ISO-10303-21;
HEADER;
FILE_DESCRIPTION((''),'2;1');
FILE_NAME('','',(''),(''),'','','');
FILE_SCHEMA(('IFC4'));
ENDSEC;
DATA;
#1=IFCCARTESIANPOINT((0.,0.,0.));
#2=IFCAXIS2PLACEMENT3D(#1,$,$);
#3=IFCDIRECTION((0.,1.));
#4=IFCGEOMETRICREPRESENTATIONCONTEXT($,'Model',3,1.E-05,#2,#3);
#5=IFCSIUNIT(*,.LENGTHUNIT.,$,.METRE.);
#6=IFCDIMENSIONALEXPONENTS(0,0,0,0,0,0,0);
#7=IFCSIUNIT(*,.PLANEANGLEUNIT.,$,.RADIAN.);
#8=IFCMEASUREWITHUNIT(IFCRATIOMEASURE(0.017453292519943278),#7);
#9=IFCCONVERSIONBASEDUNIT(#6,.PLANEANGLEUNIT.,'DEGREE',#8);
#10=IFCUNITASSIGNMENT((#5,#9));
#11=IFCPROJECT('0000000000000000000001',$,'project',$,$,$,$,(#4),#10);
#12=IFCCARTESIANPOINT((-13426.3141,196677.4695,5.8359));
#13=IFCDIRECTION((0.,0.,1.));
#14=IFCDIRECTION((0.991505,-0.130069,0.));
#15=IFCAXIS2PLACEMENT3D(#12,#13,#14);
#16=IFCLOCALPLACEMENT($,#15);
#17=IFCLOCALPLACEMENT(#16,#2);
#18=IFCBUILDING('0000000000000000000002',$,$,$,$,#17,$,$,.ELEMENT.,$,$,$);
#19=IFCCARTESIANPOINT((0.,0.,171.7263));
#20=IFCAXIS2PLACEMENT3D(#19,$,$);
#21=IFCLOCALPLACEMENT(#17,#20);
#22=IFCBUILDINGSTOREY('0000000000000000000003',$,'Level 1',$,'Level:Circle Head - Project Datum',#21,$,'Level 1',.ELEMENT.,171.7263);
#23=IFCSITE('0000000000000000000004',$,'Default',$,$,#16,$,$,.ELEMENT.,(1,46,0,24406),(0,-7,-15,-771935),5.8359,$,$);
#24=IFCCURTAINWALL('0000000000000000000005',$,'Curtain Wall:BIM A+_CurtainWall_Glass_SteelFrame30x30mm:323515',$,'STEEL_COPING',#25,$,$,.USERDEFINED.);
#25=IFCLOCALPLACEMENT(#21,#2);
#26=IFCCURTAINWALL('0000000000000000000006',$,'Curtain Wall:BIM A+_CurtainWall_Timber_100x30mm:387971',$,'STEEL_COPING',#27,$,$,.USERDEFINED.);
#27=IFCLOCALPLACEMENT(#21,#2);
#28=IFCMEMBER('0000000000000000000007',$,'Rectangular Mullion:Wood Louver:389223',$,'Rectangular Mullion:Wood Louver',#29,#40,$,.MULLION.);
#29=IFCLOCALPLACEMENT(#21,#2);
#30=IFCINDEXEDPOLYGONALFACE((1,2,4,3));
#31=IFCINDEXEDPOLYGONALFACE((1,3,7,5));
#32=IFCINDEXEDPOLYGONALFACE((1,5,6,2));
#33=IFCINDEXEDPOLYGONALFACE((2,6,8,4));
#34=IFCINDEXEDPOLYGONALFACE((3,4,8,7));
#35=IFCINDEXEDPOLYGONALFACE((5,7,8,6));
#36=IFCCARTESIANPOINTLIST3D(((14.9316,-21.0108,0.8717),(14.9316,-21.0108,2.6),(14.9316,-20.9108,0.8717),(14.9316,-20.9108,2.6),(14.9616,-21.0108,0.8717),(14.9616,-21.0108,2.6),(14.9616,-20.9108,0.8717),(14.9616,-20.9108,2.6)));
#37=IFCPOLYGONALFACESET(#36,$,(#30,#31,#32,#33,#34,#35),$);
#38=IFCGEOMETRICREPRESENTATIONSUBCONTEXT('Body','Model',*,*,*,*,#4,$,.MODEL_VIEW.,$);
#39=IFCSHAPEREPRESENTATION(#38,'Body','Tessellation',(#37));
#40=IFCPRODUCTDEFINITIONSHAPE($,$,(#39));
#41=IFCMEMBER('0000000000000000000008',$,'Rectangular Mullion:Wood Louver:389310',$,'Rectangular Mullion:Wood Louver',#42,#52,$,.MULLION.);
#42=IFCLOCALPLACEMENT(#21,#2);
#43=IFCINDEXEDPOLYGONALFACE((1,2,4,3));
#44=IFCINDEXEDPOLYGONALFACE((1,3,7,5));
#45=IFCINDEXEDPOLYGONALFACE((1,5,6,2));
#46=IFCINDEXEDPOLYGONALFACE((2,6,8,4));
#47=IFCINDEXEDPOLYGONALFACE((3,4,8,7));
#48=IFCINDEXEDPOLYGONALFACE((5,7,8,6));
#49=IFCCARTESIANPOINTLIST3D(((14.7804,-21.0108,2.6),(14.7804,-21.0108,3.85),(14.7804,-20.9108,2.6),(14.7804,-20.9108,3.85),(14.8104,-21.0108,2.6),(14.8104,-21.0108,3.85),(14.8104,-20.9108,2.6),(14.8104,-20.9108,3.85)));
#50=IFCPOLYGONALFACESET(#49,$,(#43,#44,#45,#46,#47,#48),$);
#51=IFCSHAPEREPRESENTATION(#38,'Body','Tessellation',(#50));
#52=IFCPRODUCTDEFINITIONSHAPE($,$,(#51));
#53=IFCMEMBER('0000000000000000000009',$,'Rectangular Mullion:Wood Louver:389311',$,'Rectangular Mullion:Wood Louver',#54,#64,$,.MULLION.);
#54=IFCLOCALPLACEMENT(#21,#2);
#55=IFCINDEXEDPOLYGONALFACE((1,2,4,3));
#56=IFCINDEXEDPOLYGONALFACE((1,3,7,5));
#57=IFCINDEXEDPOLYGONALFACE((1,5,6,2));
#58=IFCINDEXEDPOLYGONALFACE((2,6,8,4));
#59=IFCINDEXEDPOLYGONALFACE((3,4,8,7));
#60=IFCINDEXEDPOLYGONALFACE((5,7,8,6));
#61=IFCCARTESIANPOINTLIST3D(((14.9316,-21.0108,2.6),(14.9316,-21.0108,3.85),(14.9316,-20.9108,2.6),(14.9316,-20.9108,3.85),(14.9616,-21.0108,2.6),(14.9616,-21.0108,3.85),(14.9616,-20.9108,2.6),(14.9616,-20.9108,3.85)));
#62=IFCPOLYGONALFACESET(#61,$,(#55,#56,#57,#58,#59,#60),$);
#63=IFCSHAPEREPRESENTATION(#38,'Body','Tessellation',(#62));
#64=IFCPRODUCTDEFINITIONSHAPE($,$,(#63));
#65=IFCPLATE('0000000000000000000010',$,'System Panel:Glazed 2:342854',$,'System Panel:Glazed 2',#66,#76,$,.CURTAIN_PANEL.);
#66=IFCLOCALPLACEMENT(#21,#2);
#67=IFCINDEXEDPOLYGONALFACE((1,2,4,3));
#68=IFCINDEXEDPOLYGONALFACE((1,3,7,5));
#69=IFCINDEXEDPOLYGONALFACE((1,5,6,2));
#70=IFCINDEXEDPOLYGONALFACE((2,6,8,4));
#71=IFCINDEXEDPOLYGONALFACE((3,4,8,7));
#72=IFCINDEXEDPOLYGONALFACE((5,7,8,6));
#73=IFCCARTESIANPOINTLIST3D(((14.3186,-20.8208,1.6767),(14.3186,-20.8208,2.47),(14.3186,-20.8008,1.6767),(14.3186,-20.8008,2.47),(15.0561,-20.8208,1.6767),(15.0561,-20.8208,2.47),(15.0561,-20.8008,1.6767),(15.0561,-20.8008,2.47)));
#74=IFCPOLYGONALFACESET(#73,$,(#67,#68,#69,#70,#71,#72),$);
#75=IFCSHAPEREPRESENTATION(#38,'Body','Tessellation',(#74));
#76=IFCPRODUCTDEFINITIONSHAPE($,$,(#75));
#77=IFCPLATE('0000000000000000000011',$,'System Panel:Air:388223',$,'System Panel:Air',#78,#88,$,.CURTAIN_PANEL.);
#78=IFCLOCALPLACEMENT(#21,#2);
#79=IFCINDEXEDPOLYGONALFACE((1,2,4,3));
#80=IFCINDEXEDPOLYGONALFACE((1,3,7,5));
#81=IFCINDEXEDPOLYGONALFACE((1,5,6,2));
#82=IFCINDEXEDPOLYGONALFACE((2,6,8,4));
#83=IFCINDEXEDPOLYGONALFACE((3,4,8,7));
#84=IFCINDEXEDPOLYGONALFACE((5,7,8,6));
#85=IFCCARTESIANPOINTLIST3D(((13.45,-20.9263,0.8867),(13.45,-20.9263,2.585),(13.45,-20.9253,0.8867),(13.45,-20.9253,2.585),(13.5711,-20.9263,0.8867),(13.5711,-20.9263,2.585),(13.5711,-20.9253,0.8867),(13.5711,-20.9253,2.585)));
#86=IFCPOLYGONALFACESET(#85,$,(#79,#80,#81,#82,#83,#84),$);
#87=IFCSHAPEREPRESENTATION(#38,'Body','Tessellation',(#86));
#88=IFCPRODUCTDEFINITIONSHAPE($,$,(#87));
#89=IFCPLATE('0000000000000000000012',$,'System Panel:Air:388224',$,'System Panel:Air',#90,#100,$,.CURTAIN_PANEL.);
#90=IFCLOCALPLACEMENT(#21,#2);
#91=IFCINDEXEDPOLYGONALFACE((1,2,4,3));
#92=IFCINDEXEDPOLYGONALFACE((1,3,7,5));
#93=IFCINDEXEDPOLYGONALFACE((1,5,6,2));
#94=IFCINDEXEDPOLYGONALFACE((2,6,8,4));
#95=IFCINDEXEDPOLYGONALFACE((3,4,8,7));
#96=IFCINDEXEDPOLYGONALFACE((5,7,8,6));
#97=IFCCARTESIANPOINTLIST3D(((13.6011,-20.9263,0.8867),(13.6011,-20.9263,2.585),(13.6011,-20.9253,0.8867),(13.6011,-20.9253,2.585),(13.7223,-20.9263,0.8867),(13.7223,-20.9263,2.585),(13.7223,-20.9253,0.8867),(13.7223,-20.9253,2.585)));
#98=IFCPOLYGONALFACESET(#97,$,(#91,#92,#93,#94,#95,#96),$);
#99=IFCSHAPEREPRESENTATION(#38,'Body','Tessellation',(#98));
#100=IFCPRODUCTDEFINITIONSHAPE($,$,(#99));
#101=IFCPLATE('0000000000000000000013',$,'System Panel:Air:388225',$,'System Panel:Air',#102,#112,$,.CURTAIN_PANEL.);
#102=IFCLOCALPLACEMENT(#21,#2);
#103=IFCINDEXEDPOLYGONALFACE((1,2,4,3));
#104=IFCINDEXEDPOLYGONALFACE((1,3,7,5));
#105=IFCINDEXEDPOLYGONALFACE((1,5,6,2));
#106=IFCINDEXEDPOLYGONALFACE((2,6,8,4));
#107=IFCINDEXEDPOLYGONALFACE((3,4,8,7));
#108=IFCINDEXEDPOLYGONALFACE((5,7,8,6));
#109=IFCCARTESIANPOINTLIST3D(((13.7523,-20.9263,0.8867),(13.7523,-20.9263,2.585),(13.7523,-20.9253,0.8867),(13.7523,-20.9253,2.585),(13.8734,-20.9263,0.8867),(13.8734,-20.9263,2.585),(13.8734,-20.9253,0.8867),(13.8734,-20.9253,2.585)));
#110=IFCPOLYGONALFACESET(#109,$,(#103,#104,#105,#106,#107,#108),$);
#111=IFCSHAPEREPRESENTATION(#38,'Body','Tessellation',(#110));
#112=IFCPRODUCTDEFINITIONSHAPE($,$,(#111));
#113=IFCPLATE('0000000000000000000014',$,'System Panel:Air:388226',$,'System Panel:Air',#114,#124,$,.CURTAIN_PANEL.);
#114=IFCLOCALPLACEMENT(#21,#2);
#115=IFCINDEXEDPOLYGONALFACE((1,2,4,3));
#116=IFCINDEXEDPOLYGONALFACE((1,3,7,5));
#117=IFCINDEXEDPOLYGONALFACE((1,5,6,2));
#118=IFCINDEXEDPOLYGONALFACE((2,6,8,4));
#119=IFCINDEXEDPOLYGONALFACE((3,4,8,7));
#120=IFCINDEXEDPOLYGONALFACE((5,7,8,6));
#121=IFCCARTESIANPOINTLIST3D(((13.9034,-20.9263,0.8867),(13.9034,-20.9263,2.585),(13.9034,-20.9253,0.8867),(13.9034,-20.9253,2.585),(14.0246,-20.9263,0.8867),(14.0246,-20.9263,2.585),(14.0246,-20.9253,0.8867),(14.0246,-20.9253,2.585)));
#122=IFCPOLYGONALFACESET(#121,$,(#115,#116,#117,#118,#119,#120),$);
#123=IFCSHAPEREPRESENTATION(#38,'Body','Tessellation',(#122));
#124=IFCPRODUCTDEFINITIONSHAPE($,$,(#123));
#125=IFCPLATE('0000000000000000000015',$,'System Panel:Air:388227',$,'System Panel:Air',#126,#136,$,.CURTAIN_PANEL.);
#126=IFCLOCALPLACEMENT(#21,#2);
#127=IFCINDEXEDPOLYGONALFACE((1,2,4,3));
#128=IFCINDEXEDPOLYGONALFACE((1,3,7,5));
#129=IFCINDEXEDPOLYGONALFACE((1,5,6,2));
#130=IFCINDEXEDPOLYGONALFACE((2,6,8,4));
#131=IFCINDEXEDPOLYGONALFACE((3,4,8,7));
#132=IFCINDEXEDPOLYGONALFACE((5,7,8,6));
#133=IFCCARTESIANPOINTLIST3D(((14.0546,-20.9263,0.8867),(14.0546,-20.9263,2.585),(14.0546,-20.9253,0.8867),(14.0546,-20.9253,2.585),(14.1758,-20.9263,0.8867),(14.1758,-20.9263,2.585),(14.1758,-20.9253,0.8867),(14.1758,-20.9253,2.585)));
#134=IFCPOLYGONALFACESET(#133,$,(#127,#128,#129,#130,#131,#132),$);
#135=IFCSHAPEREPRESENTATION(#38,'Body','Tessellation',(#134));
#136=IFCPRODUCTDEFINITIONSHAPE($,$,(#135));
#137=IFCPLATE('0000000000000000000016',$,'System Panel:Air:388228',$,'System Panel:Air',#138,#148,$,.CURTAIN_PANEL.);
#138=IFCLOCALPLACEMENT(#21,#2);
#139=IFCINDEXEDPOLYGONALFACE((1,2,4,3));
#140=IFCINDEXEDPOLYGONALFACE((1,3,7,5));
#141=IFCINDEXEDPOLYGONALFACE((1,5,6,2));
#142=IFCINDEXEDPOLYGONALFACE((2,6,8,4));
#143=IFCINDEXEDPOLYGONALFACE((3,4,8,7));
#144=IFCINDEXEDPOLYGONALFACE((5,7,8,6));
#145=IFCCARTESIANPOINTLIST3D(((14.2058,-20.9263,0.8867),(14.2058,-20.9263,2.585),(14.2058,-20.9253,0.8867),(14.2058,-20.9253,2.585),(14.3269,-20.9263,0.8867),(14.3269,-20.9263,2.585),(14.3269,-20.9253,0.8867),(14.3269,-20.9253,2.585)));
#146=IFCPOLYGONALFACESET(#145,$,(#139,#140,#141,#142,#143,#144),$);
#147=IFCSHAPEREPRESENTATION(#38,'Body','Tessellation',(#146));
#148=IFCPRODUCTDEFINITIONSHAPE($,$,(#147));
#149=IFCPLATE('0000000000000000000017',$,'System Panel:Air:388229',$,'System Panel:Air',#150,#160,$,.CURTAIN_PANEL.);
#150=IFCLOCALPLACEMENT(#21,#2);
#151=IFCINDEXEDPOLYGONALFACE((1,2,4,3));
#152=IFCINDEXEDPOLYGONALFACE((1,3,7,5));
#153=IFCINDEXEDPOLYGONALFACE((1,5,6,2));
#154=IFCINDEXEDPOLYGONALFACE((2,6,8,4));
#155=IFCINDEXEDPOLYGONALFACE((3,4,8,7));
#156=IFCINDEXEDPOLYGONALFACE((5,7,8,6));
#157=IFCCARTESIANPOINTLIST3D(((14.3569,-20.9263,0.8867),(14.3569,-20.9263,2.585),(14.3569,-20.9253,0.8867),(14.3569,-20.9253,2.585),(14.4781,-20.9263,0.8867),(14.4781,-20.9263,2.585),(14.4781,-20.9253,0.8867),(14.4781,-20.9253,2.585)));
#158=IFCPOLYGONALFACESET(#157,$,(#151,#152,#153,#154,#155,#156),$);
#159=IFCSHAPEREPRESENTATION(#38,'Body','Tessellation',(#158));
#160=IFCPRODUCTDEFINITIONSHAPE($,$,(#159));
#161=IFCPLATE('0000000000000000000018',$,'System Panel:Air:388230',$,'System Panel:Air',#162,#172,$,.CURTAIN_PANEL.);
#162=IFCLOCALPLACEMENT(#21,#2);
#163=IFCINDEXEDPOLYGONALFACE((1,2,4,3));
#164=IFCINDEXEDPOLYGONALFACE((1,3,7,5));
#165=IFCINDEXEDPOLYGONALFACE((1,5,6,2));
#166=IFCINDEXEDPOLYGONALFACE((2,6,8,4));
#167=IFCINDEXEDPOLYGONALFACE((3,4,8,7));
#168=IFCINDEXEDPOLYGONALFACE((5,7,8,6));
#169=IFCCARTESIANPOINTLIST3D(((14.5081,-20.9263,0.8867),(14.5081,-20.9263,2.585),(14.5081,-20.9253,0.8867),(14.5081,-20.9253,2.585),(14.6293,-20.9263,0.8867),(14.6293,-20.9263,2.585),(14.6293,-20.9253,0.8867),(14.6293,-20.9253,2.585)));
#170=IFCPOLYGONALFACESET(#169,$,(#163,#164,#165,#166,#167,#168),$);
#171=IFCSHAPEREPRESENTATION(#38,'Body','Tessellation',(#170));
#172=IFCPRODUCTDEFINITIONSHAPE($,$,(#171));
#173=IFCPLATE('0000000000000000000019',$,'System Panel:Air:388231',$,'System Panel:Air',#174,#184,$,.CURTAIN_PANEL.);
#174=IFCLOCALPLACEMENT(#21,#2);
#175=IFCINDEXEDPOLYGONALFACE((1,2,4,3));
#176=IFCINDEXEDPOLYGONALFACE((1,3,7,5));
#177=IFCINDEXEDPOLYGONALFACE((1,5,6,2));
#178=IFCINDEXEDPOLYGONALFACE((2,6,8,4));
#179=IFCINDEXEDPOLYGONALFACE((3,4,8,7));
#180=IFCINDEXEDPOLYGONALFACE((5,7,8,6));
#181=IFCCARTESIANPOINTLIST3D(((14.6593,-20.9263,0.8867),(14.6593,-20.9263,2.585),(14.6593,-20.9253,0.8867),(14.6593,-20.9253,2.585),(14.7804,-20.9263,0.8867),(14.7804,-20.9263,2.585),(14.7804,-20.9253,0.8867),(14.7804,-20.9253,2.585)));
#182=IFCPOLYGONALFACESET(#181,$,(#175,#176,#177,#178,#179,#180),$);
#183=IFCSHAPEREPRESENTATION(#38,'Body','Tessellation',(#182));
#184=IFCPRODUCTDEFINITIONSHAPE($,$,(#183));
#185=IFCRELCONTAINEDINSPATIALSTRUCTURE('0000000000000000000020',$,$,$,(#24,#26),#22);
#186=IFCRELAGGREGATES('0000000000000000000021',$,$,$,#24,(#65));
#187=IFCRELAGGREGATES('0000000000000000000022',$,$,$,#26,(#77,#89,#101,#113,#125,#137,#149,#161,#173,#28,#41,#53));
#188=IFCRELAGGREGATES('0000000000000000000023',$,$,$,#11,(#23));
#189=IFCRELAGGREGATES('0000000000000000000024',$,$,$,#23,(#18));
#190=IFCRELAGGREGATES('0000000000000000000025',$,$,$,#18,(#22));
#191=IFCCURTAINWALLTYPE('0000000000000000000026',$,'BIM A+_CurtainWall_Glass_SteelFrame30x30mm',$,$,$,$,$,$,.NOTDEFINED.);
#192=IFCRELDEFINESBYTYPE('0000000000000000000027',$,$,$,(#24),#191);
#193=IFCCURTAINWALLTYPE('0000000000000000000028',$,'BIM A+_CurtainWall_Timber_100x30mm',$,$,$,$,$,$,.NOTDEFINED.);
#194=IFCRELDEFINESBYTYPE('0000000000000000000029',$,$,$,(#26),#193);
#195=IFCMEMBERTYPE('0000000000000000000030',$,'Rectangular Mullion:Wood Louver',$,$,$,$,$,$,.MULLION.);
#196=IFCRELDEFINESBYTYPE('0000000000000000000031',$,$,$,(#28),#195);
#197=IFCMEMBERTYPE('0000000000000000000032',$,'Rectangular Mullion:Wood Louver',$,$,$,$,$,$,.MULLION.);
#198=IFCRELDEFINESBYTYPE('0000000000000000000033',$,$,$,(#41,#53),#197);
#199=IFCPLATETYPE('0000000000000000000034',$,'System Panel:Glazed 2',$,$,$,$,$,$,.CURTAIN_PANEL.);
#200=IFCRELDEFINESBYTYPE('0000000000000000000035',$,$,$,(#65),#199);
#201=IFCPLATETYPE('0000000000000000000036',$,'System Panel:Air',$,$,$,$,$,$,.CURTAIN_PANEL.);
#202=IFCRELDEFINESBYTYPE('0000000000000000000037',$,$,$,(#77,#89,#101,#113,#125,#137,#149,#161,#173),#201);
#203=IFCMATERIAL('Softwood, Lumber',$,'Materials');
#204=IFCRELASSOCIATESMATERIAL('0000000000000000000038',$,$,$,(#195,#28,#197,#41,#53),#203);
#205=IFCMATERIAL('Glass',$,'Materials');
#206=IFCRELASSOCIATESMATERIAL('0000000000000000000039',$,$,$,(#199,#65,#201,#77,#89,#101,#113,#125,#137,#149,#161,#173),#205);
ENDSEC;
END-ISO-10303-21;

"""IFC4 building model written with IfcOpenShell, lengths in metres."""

from ifc_helpers import new_model, entity, si_unit, converted_unit, direction, frame, origin, place, context, subcontext, project, spatial, indexed_curve, outline, extrude, source, transform, mapped, material, type_object, type_shapes, element, aggregate, save


model = new_model("IFC4")

# Units and contexts
model_context = context("Model", 3, precision=1e-05, world=origin(), true_north=direction((0.0, 1.0)))
body_context = subcontext(model_context, "Body", "Model", "MODEL_VIEW")
ifc_project = project(units=[si_unit("LENGTHUNIT", "METRE"), converted_unit("PLANEANGLEUNIT", "DEGREE", entity("IfcRatioMeasure", 0.017453292519943278), si_unit("PLANEANGLEUNIT", "RADIAN"), dimensions=[0, 0, 0, 0, 0, 0, 0])], contexts=[model_context])

# Site, building, storey
site_placement = place(None, frame((-13426.3141, 196677.4695, 5.8359), z_axis=(0.0, 0.0, 1.0), x_axis=(0.991505, -0.130069, 0.0)))
site = spatial("IfcSite", under=ifc_project, at=site_placement, Name="Default", CompositionType="ELEMENT", RefLatitude=(1, 46, 0, 24406), RefLongitude=(0, -7, -15, -771935), RefElevation=5.8359)
building_placement = place(site_placement, origin())
building = spatial("IfcBuilding", under=site, at=building_placement, CompositionType="ELEMENT")
storey_placement = place(building_placement, frame((0.0, 0.0, 171.7263)))
storey = spatial("IfcBuildingStorey", under=building, at=storey_placement, Name="Level 1", ObjectType="Level:Circle Head - Project Datum", LongName="Level 1", CompositionType="ELEMENT", Elevation=171.7263)

# Curtain walls, members
curtain_wall_type_1 = type_object("IfcCurtainWallType", Name="BIM A+_CurtainWall_Glass_SteelFrame30x30mm", PredefinedType="NOTDEFINED")
curtain_wall_1_placement = place(storey_placement, frame((0.0, 0.0, -171.7263)))
curtain_wall_1 = element("IfcCurtainWall", 1, at=curtain_wall_1_placement, inside=storey, type_object=curtain_wall_type_1, Name="Curtain Wall:BIM A+_CurtainWall_Glass_SteelFrame30x30mm:323515", ObjectType="STEEL_COPING", PredefinedType="USERDEFINED")
curtain_wall_type_2 = type_object("IfcCurtainWallType", Name="BIM A+_CurtainWall_Timber_100x30mm", PredefinedType="NOTDEFINED")
curtain_wall_2_placement = place(storey_placement, frame((0.0, 0.0, -171.7263)))
curtain_wall_2 = element("IfcCurtainWall", 2, at=curtain_wall_2_placement, inside=storey, type_object=curtain_wall_type_2, Name="Curtain Wall:BIM A+_CurtainWall_Timber_100x30mm:387971", ObjectType="STEEL_COPING", PredefinedType="USERDEFINED")
ifc_material_1 = material(Name="Softwood, Lumber", Category="Materials")
member_type_1 = type_object("IfcMemberType", Name="Rectangular Mullion:Wood Louver", PredefinedType="MULLION", material=ifc_material_1)
shared_shape_1 = source(origin(), body_context, "Body", "SweptSolid", [
    extrude(outline(indexed_curve([(-0.05, -0.015), (0.05, -0.015), (0.05, 0.015), (-0.05, 0.015), (-0.05, -0.015)], self_intersect=False)), frame((0.0, 0.035, -1.7283), z_axis=(0.0, 0.0, 1.0), x_axis=(0.0, -1.0, 0.0)), (0.0, 0.0, 1.0), 1.7283),
])
type_shapes(member_type_1, [shared_shape_1])
member_1_placement = place(curtain_wall_2_placement, frame((14.9466, -20.9258, 172.598), z_axis=(0.0, 0.0, -1.0), x_axis=(1.0, 0.0, 0.0)))
member_1 = element("IfcMember", 3, at=member_1_placement, type_object=member_type_1, material=ifc_material_1, Name="Rectangular Mullion:Wood Louver:389223", ObjectType="Rectangular Mullion:Wood Louver", PredefinedType="MULLION", context=body_context, shape_type="MappedRepresentation", body=[
    mapped(shared_shape_1, transform((0.0, 0.0, 0.0), scale=1.0)),
])
member_type_2 = type_object("IfcMemberType", Name="Rectangular Mullion:Wood Louver", PredefinedType="MULLION", material=ifc_material_1)
shared_shape_2 = source(origin(), body_context, "Body", "SweptSolid", [
    extrude(outline(indexed_curve([(-0.05, -0.015), (0.05, -0.015), (0.05, 0.015), (-0.05, 0.015), (-0.05, -0.015)], self_intersect=False)), frame((0.0, 0.035, -1.25), z_axis=(0.0, 0.0, 1.0), x_axis=(0.0, -1.0, 0.0)), (0.0, 0.0, 1.0), 1.25),
])
type_shapes(member_type_2, [shared_shape_2])
member_2_placement = place(curtain_wall_2_placement, frame((14.7954, -20.9258, 174.3263), z_axis=(0.0, 0.0, -1.0), x_axis=(1.0, 0.0, 0.0)))
member_2 = element("IfcMember", 4, at=member_2_placement, type_object=member_type_2, material=ifc_material_1, Name="Rectangular Mullion:Wood Louver:389310", ObjectType="Rectangular Mullion:Wood Louver", PredefinedType="MULLION", context=body_context, shape_type="MappedRepresentation", body=[
    mapped(shared_shape_2, transform((0.0, 0.0, 0.0), scale=1.0)),
])
member_3_placement = place(curtain_wall_2_placement, frame((14.9466, -20.9258, 174.3263), z_axis=(0.0, 0.0, -1.0), x_axis=(1.0, 0.0, 0.0)))
member_3 = element("IfcMember", 5, at=member_3_placement, type_object=member_type_2, material=ifc_material_1, Name="Rectangular Mullion:Wood Louver:389311", ObjectType="Rectangular Mullion:Wood Louver", PredefinedType="MULLION", context=body_context, shape_type="MappedRepresentation", body=[
    mapped(shared_shape_2, transform((0.0, 0.0, 0.0), scale=1.0)),
])

# Plates
ifc_material_2 = material(Name="Glass", Category="Materials")
plate_type_1 = type_object("IfcPlateType", Name="System Panel:Glazed 2", PredefinedType="CURTAIN_PANEL", material=ifc_material_2)
shared_shape_3 = source(origin(), body_context, "Body", "SweptSolid", [
    extrude(outline(indexed_curve([(-0.01, -0.3688), (0.01, -0.3688), (0.01, 0.3688), (-0.01, 0.3688), (-0.01, -0.3688)], self_intersect=False)), frame((0.0, 0.0, 0.0), z_axis=(0.0, 0.0, 1.0), x_axis=(0.0, 1.0, 0.0)), (0.0, 0.0, 1.0), 0.7933),
])
type_shapes(plate_type_1, [shared_shape_3])
plate_1_placement = place(curtain_wall_1_placement, frame((14.6873, -20.8108, 173.4029)))
plate_1 = element("IfcPlate", 6, at=plate_1_placement, type_object=plate_type_1, material=ifc_material_2, Name="System Panel:Glazed 2:342854", ObjectType="System Panel:Glazed 2", PredefinedType="CURTAIN_PANEL", context=body_context, shape_type="MappedRepresentation", body=[
    mapped(shared_shape_3, transform((0.0, 0.0, 0.0), scale=1.0)),
])
aggregate(curtain_wall_1, [plate_1])
plate_type_2 = type_object("IfcPlateType", Name="System Panel:Air", PredefinedType="CURTAIN_PANEL", material=ifc_material_2)
shared_shape_4 = source(origin(), body_context, "Body", "SweptSolid", [
    extrude(outline(indexed_curve([(-0.0005, -0.0606), (0.0005, -0.0606), (0.0005, 0.0606), (-0.0005, 0.0606), (-0.0005, -0.0606)], self_intersect=False)), frame((0.0, 0.0, 0.0), z_axis=(0.0, 0.0, 1.0), x_axis=(0.0, 1.0, 0.0)), (0.0, 0.0, 1.0), 1.6983),
])
type_shapes(plate_type_2, [shared_shape_4])
plate_2_placement = place(curtain_wall_2_placement, frame((13.5105, -20.9258, 172.613)))
plate_2 = element("IfcPlate", 7, at=plate_2_placement, type_object=plate_type_2, material=ifc_material_2, Name="System Panel:Air:388223", ObjectType="System Panel:Air", PredefinedType="CURTAIN_PANEL", context=body_context, shape_type="MappedRepresentation", body=[
    mapped(shared_shape_4, transform((0.0, 0.0, 0.0), scale=1.0)),
])
plate_3_placement = place(curtain_wall_2_placement, frame((13.6617, -20.9258, 172.613)))
plate_3 = element("IfcPlate", 8, at=plate_3_placement, type_object=plate_type_2, material=ifc_material_2, Name="System Panel:Air:388224", ObjectType="System Panel:Air", PredefinedType="CURTAIN_PANEL", context=body_context, shape_type="MappedRepresentation", body=[
    mapped(shared_shape_4, transform((0.0, 0.0, 0.0), scale=1.0)),
])
plate_4_placement = place(curtain_wall_2_placement, frame((13.8129, -20.9258, 172.613)))
plate_4 = element("IfcPlate", 9, at=plate_4_placement, type_object=plate_type_2, material=ifc_material_2, Name="System Panel:Air:388225", ObjectType="System Panel:Air", PredefinedType="CURTAIN_PANEL", context=body_context, shape_type="MappedRepresentation", body=[
    mapped(shared_shape_4, transform((0.0, 0.0, 0.0), scale=1.0)),
])
plate_5_placement = place(curtain_wall_2_placement, frame((13.964, -20.9258, 172.613)))
plate_5 = element("IfcPlate", 10, at=plate_5_placement, type_object=plate_type_2, material=ifc_material_2, Name="System Panel:Air:388226", ObjectType="System Panel:Air", PredefinedType="CURTAIN_PANEL", context=body_context, shape_type="MappedRepresentation", body=[
    mapped(shared_shape_4, transform((0.0, 0.0, 0.0), scale=1.0)),
])
plate_6_placement = place(curtain_wall_2_placement, frame((14.1152, -20.9258, 172.613)))
plate_6 = element("IfcPlate", 11, at=plate_6_placement, type_object=plate_type_2, material=ifc_material_2, Name="System Panel:Air:388227", ObjectType="System Panel:Air", PredefinedType="CURTAIN_PANEL", context=body_context, shape_type="MappedRepresentation", body=[
    mapped(shared_shape_4, transform((0.0, 0.0, 0.0), scale=1.0)),
])
plate_7_placement = place(curtain_wall_2_placement, frame((14.2664, -20.9258, 172.613)))
plate_7 = element("IfcPlate", 12, at=plate_7_placement, type_object=plate_type_2, material=ifc_material_2, Name="System Panel:Air:388228", ObjectType="System Panel:Air", PredefinedType="CURTAIN_PANEL", context=body_context, shape_type="MappedRepresentation", body=[
    mapped(shared_shape_4, transform((0.0, 0.0, 0.0), scale=1.0)),
])
plate_8_placement = place(curtain_wall_2_placement, frame((14.4175, -20.9258, 172.613)))
plate_8 = element("IfcPlate", 13, at=plate_8_placement, type_object=plate_type_2, material=ifc_material_2, Name="System Panel:Air:388229", ObjectType="System Panel:Air", PredefinedType="CURTAIN_PANEL", context=body_context, shape_type="MappedRepresentation", body=[
    mapped(shared_shape_4, transform((0.0, 0.0, 0.0), scale=1.0)),
])
plate_9_placement = place(curtain_wall_2_placement, frame((14.5687, -20.9258, 172.613)))
plate_9 = element("IfcPlate", 14, at=plate_9_placement, type_object=plate_type_2, material=ifc_material_2, Name="System Panel:Air:388230", ObjectType="System Panel:Air", PredefinedType="CURTAIN_PANEL", context=body_context, shape_type="MappedRepresentation", body=[
    mapped(shared_shape_4, transform((0.0, 0.0, 0.0), scale=1.0)),
])
plate_10_placement = place(curtain_wall_2_placement, frame((14.7198, -20.9258, 172.613)))
plate_10 = element("IfcPlate", 15, at=plate_10_placement, type_object=plate_type_2, material=ifc_material_2, Name="System Panel:Air:388231", ObjectType="System Panel:Air", PredefinedType="CURTAIN_PANEL", context=body_context, shape_type="MappedRepresentation", body=[
    mapped(shared_shape_4, transform((0.0, 0.0, 0.0), scale=1.0)),
])
aggregate(curtain_wall_2, [plate_2, plate_3, plate_4, plate_5, plate_6, plate_7, plate_8, plate_9, plate_10, member_1, member_2, member_3])

save(model, "model.ifc")
